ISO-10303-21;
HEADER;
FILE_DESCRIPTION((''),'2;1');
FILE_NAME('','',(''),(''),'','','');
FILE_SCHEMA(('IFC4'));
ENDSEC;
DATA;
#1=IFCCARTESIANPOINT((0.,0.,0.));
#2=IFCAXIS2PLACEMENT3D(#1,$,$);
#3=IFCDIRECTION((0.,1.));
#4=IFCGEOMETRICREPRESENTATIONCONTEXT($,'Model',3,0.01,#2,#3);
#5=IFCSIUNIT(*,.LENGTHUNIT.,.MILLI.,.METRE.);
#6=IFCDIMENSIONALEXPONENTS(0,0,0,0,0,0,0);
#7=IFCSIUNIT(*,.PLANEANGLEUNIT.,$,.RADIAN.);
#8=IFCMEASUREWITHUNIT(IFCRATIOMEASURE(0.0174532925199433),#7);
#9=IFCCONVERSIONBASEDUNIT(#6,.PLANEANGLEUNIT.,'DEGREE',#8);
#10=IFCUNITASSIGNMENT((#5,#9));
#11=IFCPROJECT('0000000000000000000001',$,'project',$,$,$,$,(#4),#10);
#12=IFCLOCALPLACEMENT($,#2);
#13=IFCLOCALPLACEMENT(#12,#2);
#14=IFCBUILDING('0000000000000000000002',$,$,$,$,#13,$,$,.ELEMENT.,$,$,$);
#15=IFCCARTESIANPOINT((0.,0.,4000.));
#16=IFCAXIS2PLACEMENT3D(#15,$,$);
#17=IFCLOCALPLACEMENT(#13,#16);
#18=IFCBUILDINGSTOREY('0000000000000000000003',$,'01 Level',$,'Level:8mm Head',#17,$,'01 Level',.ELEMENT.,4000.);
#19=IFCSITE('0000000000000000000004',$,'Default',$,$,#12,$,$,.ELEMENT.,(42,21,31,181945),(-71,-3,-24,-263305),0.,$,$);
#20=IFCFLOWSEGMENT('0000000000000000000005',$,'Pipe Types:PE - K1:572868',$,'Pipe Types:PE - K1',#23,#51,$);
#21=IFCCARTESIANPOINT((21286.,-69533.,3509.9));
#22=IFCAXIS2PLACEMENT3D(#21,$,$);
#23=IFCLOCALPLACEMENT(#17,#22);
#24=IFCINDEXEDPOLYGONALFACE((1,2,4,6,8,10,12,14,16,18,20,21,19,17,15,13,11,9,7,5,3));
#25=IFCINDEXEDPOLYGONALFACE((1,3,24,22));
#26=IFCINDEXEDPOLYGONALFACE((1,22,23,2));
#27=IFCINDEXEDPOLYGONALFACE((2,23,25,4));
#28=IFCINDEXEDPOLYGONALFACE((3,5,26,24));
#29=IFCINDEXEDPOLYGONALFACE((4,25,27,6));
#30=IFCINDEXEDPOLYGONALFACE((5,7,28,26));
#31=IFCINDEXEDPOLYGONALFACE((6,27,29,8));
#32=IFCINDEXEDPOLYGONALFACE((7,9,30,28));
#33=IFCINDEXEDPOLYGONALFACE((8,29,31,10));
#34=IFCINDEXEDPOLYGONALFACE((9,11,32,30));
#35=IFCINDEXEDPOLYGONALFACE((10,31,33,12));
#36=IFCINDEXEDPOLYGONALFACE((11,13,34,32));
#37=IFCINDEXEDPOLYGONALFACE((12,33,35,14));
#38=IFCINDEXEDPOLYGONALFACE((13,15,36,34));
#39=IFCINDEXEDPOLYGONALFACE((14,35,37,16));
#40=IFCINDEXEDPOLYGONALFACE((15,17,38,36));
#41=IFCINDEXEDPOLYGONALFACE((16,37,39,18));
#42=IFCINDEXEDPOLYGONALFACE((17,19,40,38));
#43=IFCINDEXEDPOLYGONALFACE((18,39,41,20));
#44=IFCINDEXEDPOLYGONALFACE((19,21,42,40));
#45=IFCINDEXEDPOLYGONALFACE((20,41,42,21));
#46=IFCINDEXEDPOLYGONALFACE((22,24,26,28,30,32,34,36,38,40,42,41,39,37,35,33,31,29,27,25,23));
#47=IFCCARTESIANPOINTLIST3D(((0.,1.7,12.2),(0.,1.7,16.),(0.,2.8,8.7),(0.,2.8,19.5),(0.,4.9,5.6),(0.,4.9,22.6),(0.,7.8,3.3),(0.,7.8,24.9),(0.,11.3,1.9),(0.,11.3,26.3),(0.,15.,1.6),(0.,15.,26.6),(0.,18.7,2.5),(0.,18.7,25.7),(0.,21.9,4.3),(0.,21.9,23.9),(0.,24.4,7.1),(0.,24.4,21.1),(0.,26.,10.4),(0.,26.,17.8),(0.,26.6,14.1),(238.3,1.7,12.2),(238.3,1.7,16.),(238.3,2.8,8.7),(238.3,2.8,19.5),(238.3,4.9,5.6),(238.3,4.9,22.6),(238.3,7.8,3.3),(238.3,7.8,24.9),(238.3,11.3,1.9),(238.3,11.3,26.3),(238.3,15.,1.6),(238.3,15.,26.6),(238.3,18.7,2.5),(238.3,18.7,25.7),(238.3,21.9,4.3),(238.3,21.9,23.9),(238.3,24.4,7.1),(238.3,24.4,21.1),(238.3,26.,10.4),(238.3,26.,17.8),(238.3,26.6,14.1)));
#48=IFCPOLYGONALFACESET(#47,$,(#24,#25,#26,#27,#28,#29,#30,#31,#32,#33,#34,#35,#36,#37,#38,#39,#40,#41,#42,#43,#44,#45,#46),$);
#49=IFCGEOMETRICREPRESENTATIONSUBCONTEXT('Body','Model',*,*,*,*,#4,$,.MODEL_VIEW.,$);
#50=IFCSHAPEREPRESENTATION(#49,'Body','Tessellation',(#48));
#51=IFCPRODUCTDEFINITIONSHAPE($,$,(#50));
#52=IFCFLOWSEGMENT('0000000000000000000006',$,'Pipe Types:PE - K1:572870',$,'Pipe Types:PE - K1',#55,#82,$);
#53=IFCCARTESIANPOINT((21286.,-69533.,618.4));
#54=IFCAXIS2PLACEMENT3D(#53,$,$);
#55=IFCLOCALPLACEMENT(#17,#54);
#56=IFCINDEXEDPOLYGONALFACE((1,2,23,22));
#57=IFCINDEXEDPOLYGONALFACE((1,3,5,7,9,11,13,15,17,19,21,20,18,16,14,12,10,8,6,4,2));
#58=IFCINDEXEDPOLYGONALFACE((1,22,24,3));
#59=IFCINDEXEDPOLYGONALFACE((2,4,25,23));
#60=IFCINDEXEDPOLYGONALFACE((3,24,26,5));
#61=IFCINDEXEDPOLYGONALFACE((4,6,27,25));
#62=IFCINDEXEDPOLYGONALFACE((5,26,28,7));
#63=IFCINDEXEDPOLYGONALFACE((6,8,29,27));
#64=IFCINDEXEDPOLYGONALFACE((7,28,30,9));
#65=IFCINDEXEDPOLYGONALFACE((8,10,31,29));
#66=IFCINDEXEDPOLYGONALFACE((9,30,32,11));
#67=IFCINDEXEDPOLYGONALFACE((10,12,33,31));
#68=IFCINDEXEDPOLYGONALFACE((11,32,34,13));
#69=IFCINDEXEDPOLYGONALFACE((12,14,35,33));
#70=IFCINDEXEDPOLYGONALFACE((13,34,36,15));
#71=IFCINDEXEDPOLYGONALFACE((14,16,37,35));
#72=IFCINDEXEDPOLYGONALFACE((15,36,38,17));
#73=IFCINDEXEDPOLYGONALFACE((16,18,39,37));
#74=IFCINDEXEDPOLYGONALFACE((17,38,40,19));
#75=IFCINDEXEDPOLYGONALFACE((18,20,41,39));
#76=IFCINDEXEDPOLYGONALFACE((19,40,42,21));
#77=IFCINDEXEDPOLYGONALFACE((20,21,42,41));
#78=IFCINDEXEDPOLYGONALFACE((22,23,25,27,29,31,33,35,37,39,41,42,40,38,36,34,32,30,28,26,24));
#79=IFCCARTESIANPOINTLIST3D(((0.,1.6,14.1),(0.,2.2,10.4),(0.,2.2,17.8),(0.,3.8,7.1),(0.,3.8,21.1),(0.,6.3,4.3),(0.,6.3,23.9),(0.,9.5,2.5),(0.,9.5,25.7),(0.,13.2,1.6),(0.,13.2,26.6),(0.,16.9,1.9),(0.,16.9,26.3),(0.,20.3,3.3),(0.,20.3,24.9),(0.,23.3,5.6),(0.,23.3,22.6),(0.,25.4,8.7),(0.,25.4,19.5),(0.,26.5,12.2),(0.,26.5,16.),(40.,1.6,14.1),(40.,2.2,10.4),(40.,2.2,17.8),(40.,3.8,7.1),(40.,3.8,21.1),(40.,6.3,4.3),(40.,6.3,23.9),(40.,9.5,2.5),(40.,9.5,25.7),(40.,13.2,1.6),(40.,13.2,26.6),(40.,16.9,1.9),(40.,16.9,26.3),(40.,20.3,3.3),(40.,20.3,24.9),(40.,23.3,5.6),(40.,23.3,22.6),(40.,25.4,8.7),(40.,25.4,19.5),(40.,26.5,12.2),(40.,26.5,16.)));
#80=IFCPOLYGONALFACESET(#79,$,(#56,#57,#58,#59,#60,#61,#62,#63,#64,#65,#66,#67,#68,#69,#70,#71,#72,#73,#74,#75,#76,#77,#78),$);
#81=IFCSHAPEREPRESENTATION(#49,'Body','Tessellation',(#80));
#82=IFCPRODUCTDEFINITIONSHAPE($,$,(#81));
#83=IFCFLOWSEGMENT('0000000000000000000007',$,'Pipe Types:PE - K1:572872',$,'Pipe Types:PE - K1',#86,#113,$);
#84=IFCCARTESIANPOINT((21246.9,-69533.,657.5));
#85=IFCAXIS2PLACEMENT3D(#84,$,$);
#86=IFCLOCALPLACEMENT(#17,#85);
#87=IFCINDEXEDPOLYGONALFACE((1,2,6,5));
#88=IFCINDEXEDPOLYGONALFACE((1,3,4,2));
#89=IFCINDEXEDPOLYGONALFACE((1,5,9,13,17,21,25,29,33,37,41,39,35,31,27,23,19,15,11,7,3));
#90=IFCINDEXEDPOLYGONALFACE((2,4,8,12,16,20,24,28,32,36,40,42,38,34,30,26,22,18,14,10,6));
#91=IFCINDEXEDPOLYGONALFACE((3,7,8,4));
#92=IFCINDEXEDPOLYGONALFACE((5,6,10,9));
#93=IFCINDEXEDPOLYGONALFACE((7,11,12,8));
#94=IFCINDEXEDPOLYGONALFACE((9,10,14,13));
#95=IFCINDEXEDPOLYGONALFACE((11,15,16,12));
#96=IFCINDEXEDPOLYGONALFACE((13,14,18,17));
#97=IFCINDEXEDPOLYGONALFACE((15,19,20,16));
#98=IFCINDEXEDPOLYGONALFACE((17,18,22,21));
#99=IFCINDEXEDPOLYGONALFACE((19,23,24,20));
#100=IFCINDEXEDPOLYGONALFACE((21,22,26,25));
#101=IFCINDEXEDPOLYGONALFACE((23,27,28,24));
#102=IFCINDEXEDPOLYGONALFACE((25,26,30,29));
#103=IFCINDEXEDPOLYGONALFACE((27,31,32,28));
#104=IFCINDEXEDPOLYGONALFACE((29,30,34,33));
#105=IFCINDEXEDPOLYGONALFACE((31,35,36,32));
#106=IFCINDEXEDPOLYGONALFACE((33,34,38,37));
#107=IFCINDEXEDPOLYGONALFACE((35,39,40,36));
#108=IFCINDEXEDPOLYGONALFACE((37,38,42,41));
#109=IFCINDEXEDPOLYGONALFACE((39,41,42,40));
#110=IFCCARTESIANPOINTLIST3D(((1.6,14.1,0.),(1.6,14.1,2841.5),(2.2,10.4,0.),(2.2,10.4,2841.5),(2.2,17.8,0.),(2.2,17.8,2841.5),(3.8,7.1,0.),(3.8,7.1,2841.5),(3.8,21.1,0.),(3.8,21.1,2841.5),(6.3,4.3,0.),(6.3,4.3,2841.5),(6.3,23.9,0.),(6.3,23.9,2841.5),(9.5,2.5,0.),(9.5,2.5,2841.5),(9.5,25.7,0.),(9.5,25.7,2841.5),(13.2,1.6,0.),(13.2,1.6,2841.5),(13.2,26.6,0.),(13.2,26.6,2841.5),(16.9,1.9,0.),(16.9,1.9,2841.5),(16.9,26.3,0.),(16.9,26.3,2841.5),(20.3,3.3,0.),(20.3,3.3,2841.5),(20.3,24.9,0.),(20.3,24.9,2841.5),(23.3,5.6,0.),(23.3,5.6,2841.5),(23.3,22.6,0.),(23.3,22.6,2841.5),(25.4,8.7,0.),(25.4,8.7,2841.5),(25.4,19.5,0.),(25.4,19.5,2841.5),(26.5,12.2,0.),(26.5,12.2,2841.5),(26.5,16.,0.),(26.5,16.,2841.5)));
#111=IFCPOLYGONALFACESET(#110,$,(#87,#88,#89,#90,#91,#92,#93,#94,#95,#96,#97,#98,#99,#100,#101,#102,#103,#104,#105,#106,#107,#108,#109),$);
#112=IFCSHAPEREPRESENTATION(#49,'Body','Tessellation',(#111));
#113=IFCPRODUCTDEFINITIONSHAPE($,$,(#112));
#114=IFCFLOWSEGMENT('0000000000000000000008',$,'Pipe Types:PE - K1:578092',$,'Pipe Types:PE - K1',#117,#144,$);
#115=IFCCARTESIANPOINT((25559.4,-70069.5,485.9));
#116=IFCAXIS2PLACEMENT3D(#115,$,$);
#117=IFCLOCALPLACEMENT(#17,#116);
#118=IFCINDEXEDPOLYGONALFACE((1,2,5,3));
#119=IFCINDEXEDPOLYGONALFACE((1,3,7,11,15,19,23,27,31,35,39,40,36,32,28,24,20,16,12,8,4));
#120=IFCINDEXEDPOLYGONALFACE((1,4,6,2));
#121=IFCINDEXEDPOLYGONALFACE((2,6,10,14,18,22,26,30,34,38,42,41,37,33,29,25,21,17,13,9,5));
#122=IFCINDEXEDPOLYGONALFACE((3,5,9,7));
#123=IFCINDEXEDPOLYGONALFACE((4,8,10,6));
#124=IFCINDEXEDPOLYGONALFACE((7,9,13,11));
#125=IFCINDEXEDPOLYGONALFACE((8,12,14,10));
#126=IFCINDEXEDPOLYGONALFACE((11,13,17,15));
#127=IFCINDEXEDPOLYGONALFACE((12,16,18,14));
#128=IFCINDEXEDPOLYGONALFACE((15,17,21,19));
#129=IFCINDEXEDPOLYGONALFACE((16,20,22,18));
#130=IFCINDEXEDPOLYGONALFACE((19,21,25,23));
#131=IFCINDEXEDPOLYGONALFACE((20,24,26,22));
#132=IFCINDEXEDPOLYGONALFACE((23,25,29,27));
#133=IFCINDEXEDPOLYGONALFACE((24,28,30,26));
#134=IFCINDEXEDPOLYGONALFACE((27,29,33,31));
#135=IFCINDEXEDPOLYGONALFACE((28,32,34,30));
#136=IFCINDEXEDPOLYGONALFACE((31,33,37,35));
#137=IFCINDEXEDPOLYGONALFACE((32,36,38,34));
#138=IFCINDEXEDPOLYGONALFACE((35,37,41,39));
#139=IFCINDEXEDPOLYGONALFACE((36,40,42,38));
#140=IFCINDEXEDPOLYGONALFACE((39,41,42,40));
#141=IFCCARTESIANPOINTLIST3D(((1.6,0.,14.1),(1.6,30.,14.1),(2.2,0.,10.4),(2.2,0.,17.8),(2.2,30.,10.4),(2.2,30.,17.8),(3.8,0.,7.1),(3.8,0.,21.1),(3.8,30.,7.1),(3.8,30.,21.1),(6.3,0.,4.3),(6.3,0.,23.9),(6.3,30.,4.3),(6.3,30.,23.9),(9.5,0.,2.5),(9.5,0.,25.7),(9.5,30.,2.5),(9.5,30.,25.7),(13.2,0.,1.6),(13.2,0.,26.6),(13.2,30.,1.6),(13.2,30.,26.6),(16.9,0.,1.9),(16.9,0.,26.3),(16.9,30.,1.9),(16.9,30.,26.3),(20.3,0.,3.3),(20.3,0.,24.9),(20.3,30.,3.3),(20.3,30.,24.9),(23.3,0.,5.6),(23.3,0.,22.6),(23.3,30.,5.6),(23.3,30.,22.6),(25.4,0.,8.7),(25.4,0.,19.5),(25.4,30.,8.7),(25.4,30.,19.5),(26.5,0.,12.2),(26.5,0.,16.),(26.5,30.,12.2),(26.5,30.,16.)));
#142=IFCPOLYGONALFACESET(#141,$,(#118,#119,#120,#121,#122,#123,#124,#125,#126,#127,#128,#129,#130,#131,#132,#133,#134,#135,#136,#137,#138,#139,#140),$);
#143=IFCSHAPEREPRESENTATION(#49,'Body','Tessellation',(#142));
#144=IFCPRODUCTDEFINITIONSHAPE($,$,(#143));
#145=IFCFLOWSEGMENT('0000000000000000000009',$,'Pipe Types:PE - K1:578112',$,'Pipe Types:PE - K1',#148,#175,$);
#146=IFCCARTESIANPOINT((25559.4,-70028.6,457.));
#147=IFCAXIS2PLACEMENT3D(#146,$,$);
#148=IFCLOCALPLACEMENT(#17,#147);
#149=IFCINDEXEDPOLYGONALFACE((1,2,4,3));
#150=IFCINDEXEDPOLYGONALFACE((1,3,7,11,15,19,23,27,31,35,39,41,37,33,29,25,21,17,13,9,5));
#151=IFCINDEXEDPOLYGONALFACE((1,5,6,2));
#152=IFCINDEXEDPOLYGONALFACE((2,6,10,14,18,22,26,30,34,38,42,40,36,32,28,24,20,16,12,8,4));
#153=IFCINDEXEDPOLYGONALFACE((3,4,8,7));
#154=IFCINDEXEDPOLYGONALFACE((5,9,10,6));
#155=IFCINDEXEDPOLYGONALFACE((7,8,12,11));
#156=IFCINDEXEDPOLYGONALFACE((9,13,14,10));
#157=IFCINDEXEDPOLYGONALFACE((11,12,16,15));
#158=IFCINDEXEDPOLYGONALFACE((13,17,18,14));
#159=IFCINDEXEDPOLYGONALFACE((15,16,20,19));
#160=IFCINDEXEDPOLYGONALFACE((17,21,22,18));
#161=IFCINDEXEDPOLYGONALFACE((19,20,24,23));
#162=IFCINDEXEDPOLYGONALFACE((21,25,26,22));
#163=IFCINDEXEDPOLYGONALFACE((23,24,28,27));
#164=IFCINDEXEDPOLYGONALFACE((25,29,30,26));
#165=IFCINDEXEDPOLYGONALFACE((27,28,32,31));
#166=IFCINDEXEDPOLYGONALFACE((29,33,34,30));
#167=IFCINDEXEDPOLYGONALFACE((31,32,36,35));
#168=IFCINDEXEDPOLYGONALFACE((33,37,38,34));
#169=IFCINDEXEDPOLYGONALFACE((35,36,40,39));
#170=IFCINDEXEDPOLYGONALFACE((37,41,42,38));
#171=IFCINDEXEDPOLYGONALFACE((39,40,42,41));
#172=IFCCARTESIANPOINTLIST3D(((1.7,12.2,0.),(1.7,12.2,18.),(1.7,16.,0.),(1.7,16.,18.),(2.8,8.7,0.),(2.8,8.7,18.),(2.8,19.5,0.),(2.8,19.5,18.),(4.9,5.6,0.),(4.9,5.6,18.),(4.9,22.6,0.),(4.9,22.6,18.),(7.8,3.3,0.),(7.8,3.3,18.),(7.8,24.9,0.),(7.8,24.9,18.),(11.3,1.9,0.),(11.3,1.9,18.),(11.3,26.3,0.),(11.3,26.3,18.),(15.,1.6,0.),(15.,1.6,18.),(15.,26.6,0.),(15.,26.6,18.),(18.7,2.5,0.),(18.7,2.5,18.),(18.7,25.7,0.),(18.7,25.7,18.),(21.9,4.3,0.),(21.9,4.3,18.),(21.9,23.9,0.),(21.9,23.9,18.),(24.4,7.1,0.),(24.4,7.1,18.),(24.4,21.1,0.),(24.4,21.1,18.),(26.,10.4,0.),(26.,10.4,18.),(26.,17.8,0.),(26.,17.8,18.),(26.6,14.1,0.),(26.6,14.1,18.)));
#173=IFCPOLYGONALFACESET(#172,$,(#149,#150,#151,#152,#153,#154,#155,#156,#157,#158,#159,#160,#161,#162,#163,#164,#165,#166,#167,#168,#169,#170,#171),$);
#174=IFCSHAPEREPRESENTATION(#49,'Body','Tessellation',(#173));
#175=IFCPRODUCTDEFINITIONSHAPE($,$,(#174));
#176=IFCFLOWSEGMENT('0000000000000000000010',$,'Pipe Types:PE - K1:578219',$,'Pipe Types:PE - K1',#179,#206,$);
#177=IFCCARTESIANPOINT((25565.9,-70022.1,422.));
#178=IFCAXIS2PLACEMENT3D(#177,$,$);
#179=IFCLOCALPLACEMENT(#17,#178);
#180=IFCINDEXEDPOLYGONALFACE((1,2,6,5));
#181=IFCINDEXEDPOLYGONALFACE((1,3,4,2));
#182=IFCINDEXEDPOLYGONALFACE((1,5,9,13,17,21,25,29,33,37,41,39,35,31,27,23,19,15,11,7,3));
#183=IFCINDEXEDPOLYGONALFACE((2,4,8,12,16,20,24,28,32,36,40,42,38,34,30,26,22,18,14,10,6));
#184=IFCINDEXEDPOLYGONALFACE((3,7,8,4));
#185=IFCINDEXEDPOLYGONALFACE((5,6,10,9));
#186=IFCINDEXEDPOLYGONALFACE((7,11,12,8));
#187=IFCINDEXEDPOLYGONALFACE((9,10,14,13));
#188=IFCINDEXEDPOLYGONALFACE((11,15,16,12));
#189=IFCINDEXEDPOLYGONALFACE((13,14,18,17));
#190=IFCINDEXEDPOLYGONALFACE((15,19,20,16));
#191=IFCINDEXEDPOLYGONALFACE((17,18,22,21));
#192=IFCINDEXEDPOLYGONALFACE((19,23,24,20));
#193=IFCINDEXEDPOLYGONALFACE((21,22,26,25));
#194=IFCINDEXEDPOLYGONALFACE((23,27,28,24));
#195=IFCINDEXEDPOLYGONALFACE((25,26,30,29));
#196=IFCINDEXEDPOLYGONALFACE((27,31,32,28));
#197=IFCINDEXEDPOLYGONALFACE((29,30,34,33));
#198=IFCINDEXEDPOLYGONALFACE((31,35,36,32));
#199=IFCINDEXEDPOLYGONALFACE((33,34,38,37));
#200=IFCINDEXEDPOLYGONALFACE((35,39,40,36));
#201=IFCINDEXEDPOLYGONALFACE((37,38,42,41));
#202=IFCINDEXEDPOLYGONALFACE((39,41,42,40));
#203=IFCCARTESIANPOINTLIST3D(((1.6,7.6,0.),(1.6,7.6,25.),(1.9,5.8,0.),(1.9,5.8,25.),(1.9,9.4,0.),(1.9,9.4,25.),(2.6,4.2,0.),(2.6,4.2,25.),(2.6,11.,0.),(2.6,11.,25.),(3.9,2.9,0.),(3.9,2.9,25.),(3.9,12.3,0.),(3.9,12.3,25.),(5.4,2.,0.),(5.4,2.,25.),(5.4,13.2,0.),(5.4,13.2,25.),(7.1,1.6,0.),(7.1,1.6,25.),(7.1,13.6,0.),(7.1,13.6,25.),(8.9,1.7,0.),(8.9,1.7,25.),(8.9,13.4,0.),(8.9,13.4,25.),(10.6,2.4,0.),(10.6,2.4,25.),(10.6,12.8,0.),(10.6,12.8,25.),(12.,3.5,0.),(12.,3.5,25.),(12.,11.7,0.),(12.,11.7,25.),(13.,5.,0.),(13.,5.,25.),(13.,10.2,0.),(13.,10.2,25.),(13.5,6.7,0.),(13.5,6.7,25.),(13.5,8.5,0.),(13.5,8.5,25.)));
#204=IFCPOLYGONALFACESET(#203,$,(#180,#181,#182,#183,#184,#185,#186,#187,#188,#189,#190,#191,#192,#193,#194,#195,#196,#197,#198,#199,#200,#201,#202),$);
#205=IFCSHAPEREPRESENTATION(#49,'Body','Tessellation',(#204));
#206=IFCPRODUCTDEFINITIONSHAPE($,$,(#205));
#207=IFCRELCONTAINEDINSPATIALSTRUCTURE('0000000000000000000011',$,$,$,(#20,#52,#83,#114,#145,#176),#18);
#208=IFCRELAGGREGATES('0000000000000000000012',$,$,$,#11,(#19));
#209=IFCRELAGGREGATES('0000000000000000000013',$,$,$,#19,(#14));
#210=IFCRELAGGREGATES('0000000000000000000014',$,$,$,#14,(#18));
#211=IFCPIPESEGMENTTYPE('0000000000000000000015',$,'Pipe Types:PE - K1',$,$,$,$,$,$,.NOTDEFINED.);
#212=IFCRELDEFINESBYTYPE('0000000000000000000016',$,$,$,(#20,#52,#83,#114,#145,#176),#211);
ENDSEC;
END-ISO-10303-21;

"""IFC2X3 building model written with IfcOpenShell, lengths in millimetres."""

from ifc_helpers import new_model, entity, si_unit, converted_unit, direction, frame, frame_2d, origin, origin_2d_with_axis, place, context, subcontext, project, spatial, circle, extrude, type_object, element, save


model = new_model("IFC2X3")

# Units and contexts
model_context = context("Model", 3, precision=0.01, world=origin(), true_north=direction((0.0, 1.0)))
body_context = subcontext(model_context, "Body", "Model", "MODEL_VIEW")
ifc_project = project(units=[si_unit("LENGTHUNIT", "METRE", prefix="MILLI"), converted_unit("PLANEANGLEUNIT", "DEGREE", entity("IfcRatioMeasure", 0.0174532925199433), si_unit("PLANEANGLEUNIT", "RADIAN"), dimensions=[0, 0, 0, 0, 0, 0, 0])], contexts=[model_context])

# Site, building, storey
site_placement = place(None, origin())
site = spatial("IfcSite", under=ifc_project, at=site_placement, Name="Default", CompositionType="ELEMENT", RefLatitude=(42, 21, 31, 181945), RefLongitude=(-71, -3, -24, -263305), RefElevation=0.0)
building_placement = place(site_placement, origin())
building = spatial("IfcBuilding", under=site, at=building_placement, CompositionType="ELEMENT")
storey_placement = place(building_placement, frame((0.0, 0.0, 4000.0)))
storey = spatial("IfcBuildingStorey", under=building, at=storey_placement, Name="01 Level", ObjectType="Level:8mm Head", LongName="01 Level", CompositionType="ELEMENT", Elevation=4000.0)

# Flow segments
pipe_segment_type = type_object("IfcPipeSegmentType", Name="Pipe Types:PE - K1", PredefinedType="NOTDEFINED")
flow_segment_1_placement = place(storey_placement, frame((21286.0, -69533.0, 3509.9)))
element("IfcFlowSegment", 1, at=flow_segment_1_placement, inside=storey, type_object=pipe_segment_type, Name="Pipe Types:PE - K1:572868", ObjectType="Pipe Types:PE - K1", context=body_context, shape_type="SweptSolid", body=[
    extrude(circle(Radius=12.5, at=frame_2d((0.0, 0.0), x_axis=(1.0, 0.0))), frame((0.0, 14.1, 14.1), z_axis=(1.0, 0.0, 0.0), x_axis=(0.0, 1.0, 0.0)), (0.0, 0.0, 1.0), 238.3),
])
flow_segment_2_placement = place(storey_placement, frame((21286.0, -69533.0, 618.4)))
element("IfcFlowSegment", 2, at=flow_segment_2_placement, inside=storey, type_object=pipe_segment_type, Name="Pipe Types:PE - K1:572870", ObjectType="Pipe Types:PE - K1", context=body_context, shape_type="SweptSolid", body=[
    extrude(circle(Radius=12.5, at=frame_2d((0.0, 0.0), x_axis=(1.0, 0.0))), frame((0.0, 14.1, 14.1), z_axis=(1.0, 0.0, 0.0), x_axis=(0.0, -1.0, 0.0)), (0.0, 0.0, 1.0), 40.0),
])
flow_segment_3_placement = place(storey_placement, frame((21246.9, -69533.0, 657.5)))
element("IfcFlowSegment", 3, at=flow_segment_3_placement, inside=storey, type_object=pipe_segment_type, Name="Pipe Types:PE - K1:572872", ObjectType="Pipe Types:PE - K1", context=body_context, shape_type="SweptSolid", body=[
    extrude(circle(Radius=12.5, at=frame_2d((0.0, 0.0), x_axis=(1.0, 0.0))), frame((14.1, 14.1, 0.0), z_axis=(0.0, 0.0, 1.0), x_axis=(-1.0, 0.0, 0.0)), (0.0, 0.0, 1.0), 2841.5),
])
flow_segment_4_placement = place(storey_placement, frame((25559.4, -70069.5, 485.9)))
element("IfcFlowSegment", 4, at=flow_segment_4_placement, inside=storey, type_object=pipe_segment_type, Name="Pipe Types:PE - K1:578092", ObjectType="Pipe Types:PE - K1", context=body_context, shape_type="SweptSolid", body=[
    extrude(circle(Radius=12.5, at=origin_2d_with_axis()), frame((14.1, 0.0, 14.1), z_axis=(0.0, 1.0, 0.0), x_axis=(-1.0, 0.0, 0.0)), (0.0, 0.0, 1.0), 30.0),
])
flow_segment_5_placement = place(storey_placement, frame((25559.4, -70028.6, 457.0)))
element("IfcFlowSegment", 5, at=flow_segment_5_placement, inside=storey, type_object=pipe_segment_type, Name="Pipe Types:PE - K1:578112", ObjectType="Pipe Types:PE - K1", context=body_context, shape_type="SweptSolid", body=[
    extrude(circle(Radius=12.5, at=origin_2d_with_axis()), frame((14.1, 14.1, 0.0)), (0.0, 0.0, 1.0), 18.0),
])
flow_segment_6_placement = place(storey_placement, frame((25565.9, -70022.1, 422.0)))
element("IfcFlowSegment", 6, at=flow_segment_6_placement, inside=storey, type_object=pipe_segment_type, Name="Pipe Types:PE - K1:578219", ObjectType="Pipe Types:PE - K1", context=body_context, shape_type="SweptSolid", body=[
    extrude(circle(Radius=6.0, at=origin_2d_with_axis()), frame((7.6, 7.6, 0.0), z_axis=(0.0, 0.0, 1.0), x_axis=(-1.0, 0.0, 0.0)), (0.0, 0.0, 1.0), 25.0),
])

save(model, "model.ifc")
